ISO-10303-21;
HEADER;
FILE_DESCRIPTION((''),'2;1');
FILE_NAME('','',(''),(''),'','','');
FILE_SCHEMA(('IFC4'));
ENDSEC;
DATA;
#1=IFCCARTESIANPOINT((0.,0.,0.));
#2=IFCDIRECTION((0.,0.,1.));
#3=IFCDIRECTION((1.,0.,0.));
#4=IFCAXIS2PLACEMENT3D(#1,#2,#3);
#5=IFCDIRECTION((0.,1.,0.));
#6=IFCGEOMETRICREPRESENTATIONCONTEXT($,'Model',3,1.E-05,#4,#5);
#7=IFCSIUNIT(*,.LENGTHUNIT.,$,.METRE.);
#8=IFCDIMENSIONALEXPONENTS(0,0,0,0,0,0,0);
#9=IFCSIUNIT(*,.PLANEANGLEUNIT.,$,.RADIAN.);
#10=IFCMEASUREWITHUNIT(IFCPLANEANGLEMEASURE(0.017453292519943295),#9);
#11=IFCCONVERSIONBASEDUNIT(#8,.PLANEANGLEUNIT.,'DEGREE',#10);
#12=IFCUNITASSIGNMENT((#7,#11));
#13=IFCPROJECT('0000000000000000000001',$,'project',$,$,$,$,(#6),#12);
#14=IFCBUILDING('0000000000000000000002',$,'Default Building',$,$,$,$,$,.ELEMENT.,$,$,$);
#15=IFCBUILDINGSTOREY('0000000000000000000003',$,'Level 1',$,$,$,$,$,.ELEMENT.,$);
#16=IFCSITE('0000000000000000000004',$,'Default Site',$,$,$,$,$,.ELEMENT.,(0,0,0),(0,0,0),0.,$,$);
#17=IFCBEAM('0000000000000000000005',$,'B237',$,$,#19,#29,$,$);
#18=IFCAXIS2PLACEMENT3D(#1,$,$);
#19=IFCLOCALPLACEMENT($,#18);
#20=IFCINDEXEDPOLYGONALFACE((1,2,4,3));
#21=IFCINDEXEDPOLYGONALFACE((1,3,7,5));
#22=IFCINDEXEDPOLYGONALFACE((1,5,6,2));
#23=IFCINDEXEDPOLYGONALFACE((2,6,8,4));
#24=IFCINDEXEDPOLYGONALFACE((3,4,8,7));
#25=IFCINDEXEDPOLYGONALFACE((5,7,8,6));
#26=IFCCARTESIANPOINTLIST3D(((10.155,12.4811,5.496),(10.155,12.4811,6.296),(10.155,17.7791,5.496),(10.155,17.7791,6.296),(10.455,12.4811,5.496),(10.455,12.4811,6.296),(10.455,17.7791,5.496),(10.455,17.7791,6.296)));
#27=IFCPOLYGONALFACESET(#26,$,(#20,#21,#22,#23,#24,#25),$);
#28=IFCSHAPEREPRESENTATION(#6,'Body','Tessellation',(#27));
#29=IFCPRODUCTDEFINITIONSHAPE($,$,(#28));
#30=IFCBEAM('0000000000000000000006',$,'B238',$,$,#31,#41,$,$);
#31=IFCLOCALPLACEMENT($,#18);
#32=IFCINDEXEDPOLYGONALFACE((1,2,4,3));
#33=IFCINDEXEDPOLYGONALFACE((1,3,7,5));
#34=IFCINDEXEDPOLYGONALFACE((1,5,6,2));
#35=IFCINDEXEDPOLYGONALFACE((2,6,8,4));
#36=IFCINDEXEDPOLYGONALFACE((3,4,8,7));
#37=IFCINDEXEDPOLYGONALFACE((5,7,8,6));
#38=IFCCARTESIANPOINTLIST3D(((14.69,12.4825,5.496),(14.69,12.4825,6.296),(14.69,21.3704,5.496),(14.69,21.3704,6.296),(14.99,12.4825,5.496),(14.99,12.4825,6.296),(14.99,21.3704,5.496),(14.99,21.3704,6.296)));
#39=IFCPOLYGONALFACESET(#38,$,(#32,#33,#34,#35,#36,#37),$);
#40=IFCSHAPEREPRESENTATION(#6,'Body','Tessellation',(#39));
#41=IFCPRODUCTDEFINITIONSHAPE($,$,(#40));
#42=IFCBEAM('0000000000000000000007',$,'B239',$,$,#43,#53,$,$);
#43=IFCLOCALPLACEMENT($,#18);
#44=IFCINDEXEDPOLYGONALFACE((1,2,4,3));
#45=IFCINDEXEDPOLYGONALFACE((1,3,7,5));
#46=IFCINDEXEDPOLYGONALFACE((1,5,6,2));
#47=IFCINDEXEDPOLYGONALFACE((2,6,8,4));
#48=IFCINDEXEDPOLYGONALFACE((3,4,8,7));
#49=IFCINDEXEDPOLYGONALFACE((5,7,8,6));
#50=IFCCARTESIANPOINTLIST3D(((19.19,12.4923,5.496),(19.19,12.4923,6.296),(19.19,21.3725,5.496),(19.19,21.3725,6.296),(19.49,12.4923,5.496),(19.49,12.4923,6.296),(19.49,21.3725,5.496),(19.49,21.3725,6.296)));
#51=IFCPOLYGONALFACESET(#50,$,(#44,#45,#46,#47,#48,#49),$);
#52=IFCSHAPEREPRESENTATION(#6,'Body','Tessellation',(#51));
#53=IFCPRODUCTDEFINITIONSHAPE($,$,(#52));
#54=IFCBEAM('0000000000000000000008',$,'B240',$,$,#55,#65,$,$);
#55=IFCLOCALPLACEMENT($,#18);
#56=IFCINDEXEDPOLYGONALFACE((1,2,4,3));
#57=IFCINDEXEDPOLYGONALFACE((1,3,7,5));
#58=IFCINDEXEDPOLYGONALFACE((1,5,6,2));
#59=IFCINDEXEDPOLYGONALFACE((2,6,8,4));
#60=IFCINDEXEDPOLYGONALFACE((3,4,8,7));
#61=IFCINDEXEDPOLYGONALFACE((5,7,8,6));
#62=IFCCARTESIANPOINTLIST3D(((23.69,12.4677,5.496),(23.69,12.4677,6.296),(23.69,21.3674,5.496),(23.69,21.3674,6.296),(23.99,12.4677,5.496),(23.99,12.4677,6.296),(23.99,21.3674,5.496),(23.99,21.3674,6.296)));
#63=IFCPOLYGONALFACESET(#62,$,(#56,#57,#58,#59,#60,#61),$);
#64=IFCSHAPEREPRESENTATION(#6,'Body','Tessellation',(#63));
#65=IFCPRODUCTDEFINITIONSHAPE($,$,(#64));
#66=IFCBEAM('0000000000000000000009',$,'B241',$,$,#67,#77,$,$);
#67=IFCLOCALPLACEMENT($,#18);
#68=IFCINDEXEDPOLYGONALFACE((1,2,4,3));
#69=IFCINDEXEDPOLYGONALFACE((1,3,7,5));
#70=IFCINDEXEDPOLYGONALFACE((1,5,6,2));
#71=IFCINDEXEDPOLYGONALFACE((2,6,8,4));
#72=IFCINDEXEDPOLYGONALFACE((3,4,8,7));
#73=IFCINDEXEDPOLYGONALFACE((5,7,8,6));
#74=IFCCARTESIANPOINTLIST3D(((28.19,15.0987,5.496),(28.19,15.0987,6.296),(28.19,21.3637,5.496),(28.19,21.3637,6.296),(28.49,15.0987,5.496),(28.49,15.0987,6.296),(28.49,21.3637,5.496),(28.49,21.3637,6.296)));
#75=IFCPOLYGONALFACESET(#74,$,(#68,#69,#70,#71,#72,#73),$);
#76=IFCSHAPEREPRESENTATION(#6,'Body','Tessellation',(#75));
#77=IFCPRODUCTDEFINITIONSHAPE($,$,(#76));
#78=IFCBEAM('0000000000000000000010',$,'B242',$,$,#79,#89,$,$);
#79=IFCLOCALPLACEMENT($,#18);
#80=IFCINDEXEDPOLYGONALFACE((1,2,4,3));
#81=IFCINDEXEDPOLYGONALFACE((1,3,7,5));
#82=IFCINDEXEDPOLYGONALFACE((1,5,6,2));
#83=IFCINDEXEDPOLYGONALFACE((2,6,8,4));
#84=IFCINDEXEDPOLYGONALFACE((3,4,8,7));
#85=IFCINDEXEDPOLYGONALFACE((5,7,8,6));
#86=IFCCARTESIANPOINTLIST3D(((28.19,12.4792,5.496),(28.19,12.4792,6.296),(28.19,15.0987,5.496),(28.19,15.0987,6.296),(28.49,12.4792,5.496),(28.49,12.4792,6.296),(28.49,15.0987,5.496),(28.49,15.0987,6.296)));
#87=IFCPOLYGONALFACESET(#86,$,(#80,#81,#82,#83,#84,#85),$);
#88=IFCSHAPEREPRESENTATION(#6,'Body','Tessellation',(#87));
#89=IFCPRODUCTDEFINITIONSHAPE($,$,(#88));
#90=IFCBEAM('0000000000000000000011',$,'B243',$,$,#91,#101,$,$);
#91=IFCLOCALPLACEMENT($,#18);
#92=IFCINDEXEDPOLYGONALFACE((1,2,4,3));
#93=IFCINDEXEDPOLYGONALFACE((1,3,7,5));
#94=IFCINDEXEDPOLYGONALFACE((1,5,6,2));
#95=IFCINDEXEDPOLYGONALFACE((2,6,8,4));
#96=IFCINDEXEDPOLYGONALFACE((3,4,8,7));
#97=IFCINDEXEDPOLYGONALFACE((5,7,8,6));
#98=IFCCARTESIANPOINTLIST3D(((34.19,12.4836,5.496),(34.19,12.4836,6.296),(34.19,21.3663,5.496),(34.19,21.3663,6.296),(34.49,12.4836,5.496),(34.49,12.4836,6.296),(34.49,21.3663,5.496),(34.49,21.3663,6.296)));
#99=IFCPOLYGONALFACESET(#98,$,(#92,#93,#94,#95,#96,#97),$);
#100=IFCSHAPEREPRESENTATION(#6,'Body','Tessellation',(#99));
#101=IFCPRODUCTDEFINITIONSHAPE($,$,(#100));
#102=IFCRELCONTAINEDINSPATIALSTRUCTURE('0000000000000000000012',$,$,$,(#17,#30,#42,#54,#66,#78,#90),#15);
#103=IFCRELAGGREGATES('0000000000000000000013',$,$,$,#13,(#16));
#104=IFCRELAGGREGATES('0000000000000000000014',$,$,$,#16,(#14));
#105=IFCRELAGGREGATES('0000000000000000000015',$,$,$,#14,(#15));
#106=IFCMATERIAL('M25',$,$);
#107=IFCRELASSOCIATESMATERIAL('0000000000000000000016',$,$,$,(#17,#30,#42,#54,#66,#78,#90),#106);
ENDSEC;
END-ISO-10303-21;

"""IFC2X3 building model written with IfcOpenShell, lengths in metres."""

from ifc_helpers import new_model, entity, si_unit, converted_unit, direction, frame, frame_2d, origin_with_axes, place, context, project, spatial, rectangle, extrude, material, element, save


model = new_model("IFC2X3")

# Units and contexts
model_context = context("Model", 3, precision=1e-05, world=origin_with_axes(), true_north=direction((0.0, 1.0, 0.0)))
ifc_project = project(units=[si_unit("LENGTHUNIT", "METRE"), converted_unit("PLANEANGLEUNIT", "DEGREE", entity("IfcPlaneAngleMeasure", 0.017453292519943295), si_unit("PLANEANGLEUNIT", "RADIAN"), dimensions=[0, 0, 0, 0, 0, 0, 0])], contexts=[model_context])

# Site, building, storey
site = spatial("IfcSite", under=ifc_project, Name="Default Site", CompositionType="ELEMENT", RefLatitude=(0, 0, 0), RefLongitude=(0, 0, 0), RefElevation=0.0)
building = spatial("IfcBuilding", under=site, Name="Default Building", CompositionType="ELEMENT")
storey = spatial("IfcBuildingStorey", under=building, Name="Level 1", CompositionType="ELEMENT")

# Beams
ifc_material = material(Name="M25")
placement = place(None, origin_with_axes())
element("IfcBeam", 1, at=placement, inside=storey, material=ifc_material, Name="B237", context=model_context, shape_type="SweptSolid", body=[
    extrude(rectangle(XDim=0.3, YDim=0.8, at=frame_2d((0.0, 0.0), x_axis=(0.0, 1.0, 0.0))), frame((10.305, 17.7791, 5.896), z_axis=(0.0, -1.0, 0.0), x_axis=(0.0, 0.0, -1.0)), (0.0, 0.0, 1.0), 5.298),
])
element("IfcBeam", 2, at=placement, inside=storey, material=ifc_material, Name="B238", context=model_context, shape_type="SweptSolid", body=[
    extrude(rectangle(XDim=0.3, YDim=0.8, at=frame_2d((0.0, 0.0), x_axis=(0.0, 1.0, 0.0))), frame((14.84, 21.3704, 5.896), z_axis=(0.0, -1.0, 0.0), x_axis=(0.0, 0.0, -1.0)), (0.0, 0.0, 1.0), 8.8879),
])
element("IfcBeam", 3, at=placement, inside=storey, material=ifc_material, Name="B239", context=model_context, shape_type="SweptSolid", body=[
    extrude(rectangle(XDim=0.3, YDim=0.8, at=frame_2d((0.0, 0.0), x_axis=(0.0, 1.0, 0.0))), frame((19.34, 21.3725, 5.896), z_axis=(0.0, -1.0, 0.0), x_axis=(0.0, 0.0, -1.0)), (0.0, 0.0, 1.0), 8.8802),
])
element("IfcBeam", 4, at=placement, inside=storey, material=ifc_material, Name="B240", context=model_context, shape_type="SweptSolid", body=[
    extrude(rectangle(XDim=0.3, YDim=0.8, at=frame_2d((0.0, 0.0), x_axis=(0.0, 1.0, 0.0))), frame((23.84, 21.3674, 5.896), z_axis=(0.0, -1.0, 0.0), x_axis=(0.0, 0.0, -1.0)), (0.0, 0.0, 1.0), 8.8997),
])
element("IfcBeam", 5, at=placement, inside=storey, material=ifc_material, Name="B241", context=model_context, shape_type="SweptSolid", body=[
    extrude(rectangle(XDim=0.3, YDim=0.8, at=frame_2d((0.0, 0.0), x_axis=(0.0, 1.0, 0.0))), frame((28.34, 21.3637, 5.896), z_axis=(0.0, -1.0, 0.0), x_axis=(0.0, 0.0, -1.0)), (0.0, 0.0, 1.0), 6.265),
])
element("IfcBeam", 6, at=placement, inside=storey, material=ifc_material, Name="B242", context=model_context, shape_type="SweptSolid", body=[
    extrude(rectangle(XDim=0.3, YDim=0.8, at=frame_2d((0.0, 0.0), x_axis=(0.0, 1.0, 0.0))), frame((28.34, 15.0987, 5.896), z_axis=(0.0, -1.0, 0.0), x_axis=(0.0, 0.0, -1.0)), (0.0, 0.0, 1.0), 2.6195),
])
element("IfcBeam", 7, at=placement, inside=storey, material=ifc_material, Name="B243", context=model_context, shape_type="SweptSolid", body=[
    extrude(rectangle(XDim=0.3, YDim=0.8, at=frame_2d((0.0, 0.0), x_axis=(0.0, 1.0, 0.0))), frame((34.34, 12.4836, 5.896), z_axis=(0.0, 1.0, 0.0), x_axis=(0.0, 0.0, -1.0)), (0.0, 0.0, 1.0), 8.8827),
])

save(model, "model.ifc")
